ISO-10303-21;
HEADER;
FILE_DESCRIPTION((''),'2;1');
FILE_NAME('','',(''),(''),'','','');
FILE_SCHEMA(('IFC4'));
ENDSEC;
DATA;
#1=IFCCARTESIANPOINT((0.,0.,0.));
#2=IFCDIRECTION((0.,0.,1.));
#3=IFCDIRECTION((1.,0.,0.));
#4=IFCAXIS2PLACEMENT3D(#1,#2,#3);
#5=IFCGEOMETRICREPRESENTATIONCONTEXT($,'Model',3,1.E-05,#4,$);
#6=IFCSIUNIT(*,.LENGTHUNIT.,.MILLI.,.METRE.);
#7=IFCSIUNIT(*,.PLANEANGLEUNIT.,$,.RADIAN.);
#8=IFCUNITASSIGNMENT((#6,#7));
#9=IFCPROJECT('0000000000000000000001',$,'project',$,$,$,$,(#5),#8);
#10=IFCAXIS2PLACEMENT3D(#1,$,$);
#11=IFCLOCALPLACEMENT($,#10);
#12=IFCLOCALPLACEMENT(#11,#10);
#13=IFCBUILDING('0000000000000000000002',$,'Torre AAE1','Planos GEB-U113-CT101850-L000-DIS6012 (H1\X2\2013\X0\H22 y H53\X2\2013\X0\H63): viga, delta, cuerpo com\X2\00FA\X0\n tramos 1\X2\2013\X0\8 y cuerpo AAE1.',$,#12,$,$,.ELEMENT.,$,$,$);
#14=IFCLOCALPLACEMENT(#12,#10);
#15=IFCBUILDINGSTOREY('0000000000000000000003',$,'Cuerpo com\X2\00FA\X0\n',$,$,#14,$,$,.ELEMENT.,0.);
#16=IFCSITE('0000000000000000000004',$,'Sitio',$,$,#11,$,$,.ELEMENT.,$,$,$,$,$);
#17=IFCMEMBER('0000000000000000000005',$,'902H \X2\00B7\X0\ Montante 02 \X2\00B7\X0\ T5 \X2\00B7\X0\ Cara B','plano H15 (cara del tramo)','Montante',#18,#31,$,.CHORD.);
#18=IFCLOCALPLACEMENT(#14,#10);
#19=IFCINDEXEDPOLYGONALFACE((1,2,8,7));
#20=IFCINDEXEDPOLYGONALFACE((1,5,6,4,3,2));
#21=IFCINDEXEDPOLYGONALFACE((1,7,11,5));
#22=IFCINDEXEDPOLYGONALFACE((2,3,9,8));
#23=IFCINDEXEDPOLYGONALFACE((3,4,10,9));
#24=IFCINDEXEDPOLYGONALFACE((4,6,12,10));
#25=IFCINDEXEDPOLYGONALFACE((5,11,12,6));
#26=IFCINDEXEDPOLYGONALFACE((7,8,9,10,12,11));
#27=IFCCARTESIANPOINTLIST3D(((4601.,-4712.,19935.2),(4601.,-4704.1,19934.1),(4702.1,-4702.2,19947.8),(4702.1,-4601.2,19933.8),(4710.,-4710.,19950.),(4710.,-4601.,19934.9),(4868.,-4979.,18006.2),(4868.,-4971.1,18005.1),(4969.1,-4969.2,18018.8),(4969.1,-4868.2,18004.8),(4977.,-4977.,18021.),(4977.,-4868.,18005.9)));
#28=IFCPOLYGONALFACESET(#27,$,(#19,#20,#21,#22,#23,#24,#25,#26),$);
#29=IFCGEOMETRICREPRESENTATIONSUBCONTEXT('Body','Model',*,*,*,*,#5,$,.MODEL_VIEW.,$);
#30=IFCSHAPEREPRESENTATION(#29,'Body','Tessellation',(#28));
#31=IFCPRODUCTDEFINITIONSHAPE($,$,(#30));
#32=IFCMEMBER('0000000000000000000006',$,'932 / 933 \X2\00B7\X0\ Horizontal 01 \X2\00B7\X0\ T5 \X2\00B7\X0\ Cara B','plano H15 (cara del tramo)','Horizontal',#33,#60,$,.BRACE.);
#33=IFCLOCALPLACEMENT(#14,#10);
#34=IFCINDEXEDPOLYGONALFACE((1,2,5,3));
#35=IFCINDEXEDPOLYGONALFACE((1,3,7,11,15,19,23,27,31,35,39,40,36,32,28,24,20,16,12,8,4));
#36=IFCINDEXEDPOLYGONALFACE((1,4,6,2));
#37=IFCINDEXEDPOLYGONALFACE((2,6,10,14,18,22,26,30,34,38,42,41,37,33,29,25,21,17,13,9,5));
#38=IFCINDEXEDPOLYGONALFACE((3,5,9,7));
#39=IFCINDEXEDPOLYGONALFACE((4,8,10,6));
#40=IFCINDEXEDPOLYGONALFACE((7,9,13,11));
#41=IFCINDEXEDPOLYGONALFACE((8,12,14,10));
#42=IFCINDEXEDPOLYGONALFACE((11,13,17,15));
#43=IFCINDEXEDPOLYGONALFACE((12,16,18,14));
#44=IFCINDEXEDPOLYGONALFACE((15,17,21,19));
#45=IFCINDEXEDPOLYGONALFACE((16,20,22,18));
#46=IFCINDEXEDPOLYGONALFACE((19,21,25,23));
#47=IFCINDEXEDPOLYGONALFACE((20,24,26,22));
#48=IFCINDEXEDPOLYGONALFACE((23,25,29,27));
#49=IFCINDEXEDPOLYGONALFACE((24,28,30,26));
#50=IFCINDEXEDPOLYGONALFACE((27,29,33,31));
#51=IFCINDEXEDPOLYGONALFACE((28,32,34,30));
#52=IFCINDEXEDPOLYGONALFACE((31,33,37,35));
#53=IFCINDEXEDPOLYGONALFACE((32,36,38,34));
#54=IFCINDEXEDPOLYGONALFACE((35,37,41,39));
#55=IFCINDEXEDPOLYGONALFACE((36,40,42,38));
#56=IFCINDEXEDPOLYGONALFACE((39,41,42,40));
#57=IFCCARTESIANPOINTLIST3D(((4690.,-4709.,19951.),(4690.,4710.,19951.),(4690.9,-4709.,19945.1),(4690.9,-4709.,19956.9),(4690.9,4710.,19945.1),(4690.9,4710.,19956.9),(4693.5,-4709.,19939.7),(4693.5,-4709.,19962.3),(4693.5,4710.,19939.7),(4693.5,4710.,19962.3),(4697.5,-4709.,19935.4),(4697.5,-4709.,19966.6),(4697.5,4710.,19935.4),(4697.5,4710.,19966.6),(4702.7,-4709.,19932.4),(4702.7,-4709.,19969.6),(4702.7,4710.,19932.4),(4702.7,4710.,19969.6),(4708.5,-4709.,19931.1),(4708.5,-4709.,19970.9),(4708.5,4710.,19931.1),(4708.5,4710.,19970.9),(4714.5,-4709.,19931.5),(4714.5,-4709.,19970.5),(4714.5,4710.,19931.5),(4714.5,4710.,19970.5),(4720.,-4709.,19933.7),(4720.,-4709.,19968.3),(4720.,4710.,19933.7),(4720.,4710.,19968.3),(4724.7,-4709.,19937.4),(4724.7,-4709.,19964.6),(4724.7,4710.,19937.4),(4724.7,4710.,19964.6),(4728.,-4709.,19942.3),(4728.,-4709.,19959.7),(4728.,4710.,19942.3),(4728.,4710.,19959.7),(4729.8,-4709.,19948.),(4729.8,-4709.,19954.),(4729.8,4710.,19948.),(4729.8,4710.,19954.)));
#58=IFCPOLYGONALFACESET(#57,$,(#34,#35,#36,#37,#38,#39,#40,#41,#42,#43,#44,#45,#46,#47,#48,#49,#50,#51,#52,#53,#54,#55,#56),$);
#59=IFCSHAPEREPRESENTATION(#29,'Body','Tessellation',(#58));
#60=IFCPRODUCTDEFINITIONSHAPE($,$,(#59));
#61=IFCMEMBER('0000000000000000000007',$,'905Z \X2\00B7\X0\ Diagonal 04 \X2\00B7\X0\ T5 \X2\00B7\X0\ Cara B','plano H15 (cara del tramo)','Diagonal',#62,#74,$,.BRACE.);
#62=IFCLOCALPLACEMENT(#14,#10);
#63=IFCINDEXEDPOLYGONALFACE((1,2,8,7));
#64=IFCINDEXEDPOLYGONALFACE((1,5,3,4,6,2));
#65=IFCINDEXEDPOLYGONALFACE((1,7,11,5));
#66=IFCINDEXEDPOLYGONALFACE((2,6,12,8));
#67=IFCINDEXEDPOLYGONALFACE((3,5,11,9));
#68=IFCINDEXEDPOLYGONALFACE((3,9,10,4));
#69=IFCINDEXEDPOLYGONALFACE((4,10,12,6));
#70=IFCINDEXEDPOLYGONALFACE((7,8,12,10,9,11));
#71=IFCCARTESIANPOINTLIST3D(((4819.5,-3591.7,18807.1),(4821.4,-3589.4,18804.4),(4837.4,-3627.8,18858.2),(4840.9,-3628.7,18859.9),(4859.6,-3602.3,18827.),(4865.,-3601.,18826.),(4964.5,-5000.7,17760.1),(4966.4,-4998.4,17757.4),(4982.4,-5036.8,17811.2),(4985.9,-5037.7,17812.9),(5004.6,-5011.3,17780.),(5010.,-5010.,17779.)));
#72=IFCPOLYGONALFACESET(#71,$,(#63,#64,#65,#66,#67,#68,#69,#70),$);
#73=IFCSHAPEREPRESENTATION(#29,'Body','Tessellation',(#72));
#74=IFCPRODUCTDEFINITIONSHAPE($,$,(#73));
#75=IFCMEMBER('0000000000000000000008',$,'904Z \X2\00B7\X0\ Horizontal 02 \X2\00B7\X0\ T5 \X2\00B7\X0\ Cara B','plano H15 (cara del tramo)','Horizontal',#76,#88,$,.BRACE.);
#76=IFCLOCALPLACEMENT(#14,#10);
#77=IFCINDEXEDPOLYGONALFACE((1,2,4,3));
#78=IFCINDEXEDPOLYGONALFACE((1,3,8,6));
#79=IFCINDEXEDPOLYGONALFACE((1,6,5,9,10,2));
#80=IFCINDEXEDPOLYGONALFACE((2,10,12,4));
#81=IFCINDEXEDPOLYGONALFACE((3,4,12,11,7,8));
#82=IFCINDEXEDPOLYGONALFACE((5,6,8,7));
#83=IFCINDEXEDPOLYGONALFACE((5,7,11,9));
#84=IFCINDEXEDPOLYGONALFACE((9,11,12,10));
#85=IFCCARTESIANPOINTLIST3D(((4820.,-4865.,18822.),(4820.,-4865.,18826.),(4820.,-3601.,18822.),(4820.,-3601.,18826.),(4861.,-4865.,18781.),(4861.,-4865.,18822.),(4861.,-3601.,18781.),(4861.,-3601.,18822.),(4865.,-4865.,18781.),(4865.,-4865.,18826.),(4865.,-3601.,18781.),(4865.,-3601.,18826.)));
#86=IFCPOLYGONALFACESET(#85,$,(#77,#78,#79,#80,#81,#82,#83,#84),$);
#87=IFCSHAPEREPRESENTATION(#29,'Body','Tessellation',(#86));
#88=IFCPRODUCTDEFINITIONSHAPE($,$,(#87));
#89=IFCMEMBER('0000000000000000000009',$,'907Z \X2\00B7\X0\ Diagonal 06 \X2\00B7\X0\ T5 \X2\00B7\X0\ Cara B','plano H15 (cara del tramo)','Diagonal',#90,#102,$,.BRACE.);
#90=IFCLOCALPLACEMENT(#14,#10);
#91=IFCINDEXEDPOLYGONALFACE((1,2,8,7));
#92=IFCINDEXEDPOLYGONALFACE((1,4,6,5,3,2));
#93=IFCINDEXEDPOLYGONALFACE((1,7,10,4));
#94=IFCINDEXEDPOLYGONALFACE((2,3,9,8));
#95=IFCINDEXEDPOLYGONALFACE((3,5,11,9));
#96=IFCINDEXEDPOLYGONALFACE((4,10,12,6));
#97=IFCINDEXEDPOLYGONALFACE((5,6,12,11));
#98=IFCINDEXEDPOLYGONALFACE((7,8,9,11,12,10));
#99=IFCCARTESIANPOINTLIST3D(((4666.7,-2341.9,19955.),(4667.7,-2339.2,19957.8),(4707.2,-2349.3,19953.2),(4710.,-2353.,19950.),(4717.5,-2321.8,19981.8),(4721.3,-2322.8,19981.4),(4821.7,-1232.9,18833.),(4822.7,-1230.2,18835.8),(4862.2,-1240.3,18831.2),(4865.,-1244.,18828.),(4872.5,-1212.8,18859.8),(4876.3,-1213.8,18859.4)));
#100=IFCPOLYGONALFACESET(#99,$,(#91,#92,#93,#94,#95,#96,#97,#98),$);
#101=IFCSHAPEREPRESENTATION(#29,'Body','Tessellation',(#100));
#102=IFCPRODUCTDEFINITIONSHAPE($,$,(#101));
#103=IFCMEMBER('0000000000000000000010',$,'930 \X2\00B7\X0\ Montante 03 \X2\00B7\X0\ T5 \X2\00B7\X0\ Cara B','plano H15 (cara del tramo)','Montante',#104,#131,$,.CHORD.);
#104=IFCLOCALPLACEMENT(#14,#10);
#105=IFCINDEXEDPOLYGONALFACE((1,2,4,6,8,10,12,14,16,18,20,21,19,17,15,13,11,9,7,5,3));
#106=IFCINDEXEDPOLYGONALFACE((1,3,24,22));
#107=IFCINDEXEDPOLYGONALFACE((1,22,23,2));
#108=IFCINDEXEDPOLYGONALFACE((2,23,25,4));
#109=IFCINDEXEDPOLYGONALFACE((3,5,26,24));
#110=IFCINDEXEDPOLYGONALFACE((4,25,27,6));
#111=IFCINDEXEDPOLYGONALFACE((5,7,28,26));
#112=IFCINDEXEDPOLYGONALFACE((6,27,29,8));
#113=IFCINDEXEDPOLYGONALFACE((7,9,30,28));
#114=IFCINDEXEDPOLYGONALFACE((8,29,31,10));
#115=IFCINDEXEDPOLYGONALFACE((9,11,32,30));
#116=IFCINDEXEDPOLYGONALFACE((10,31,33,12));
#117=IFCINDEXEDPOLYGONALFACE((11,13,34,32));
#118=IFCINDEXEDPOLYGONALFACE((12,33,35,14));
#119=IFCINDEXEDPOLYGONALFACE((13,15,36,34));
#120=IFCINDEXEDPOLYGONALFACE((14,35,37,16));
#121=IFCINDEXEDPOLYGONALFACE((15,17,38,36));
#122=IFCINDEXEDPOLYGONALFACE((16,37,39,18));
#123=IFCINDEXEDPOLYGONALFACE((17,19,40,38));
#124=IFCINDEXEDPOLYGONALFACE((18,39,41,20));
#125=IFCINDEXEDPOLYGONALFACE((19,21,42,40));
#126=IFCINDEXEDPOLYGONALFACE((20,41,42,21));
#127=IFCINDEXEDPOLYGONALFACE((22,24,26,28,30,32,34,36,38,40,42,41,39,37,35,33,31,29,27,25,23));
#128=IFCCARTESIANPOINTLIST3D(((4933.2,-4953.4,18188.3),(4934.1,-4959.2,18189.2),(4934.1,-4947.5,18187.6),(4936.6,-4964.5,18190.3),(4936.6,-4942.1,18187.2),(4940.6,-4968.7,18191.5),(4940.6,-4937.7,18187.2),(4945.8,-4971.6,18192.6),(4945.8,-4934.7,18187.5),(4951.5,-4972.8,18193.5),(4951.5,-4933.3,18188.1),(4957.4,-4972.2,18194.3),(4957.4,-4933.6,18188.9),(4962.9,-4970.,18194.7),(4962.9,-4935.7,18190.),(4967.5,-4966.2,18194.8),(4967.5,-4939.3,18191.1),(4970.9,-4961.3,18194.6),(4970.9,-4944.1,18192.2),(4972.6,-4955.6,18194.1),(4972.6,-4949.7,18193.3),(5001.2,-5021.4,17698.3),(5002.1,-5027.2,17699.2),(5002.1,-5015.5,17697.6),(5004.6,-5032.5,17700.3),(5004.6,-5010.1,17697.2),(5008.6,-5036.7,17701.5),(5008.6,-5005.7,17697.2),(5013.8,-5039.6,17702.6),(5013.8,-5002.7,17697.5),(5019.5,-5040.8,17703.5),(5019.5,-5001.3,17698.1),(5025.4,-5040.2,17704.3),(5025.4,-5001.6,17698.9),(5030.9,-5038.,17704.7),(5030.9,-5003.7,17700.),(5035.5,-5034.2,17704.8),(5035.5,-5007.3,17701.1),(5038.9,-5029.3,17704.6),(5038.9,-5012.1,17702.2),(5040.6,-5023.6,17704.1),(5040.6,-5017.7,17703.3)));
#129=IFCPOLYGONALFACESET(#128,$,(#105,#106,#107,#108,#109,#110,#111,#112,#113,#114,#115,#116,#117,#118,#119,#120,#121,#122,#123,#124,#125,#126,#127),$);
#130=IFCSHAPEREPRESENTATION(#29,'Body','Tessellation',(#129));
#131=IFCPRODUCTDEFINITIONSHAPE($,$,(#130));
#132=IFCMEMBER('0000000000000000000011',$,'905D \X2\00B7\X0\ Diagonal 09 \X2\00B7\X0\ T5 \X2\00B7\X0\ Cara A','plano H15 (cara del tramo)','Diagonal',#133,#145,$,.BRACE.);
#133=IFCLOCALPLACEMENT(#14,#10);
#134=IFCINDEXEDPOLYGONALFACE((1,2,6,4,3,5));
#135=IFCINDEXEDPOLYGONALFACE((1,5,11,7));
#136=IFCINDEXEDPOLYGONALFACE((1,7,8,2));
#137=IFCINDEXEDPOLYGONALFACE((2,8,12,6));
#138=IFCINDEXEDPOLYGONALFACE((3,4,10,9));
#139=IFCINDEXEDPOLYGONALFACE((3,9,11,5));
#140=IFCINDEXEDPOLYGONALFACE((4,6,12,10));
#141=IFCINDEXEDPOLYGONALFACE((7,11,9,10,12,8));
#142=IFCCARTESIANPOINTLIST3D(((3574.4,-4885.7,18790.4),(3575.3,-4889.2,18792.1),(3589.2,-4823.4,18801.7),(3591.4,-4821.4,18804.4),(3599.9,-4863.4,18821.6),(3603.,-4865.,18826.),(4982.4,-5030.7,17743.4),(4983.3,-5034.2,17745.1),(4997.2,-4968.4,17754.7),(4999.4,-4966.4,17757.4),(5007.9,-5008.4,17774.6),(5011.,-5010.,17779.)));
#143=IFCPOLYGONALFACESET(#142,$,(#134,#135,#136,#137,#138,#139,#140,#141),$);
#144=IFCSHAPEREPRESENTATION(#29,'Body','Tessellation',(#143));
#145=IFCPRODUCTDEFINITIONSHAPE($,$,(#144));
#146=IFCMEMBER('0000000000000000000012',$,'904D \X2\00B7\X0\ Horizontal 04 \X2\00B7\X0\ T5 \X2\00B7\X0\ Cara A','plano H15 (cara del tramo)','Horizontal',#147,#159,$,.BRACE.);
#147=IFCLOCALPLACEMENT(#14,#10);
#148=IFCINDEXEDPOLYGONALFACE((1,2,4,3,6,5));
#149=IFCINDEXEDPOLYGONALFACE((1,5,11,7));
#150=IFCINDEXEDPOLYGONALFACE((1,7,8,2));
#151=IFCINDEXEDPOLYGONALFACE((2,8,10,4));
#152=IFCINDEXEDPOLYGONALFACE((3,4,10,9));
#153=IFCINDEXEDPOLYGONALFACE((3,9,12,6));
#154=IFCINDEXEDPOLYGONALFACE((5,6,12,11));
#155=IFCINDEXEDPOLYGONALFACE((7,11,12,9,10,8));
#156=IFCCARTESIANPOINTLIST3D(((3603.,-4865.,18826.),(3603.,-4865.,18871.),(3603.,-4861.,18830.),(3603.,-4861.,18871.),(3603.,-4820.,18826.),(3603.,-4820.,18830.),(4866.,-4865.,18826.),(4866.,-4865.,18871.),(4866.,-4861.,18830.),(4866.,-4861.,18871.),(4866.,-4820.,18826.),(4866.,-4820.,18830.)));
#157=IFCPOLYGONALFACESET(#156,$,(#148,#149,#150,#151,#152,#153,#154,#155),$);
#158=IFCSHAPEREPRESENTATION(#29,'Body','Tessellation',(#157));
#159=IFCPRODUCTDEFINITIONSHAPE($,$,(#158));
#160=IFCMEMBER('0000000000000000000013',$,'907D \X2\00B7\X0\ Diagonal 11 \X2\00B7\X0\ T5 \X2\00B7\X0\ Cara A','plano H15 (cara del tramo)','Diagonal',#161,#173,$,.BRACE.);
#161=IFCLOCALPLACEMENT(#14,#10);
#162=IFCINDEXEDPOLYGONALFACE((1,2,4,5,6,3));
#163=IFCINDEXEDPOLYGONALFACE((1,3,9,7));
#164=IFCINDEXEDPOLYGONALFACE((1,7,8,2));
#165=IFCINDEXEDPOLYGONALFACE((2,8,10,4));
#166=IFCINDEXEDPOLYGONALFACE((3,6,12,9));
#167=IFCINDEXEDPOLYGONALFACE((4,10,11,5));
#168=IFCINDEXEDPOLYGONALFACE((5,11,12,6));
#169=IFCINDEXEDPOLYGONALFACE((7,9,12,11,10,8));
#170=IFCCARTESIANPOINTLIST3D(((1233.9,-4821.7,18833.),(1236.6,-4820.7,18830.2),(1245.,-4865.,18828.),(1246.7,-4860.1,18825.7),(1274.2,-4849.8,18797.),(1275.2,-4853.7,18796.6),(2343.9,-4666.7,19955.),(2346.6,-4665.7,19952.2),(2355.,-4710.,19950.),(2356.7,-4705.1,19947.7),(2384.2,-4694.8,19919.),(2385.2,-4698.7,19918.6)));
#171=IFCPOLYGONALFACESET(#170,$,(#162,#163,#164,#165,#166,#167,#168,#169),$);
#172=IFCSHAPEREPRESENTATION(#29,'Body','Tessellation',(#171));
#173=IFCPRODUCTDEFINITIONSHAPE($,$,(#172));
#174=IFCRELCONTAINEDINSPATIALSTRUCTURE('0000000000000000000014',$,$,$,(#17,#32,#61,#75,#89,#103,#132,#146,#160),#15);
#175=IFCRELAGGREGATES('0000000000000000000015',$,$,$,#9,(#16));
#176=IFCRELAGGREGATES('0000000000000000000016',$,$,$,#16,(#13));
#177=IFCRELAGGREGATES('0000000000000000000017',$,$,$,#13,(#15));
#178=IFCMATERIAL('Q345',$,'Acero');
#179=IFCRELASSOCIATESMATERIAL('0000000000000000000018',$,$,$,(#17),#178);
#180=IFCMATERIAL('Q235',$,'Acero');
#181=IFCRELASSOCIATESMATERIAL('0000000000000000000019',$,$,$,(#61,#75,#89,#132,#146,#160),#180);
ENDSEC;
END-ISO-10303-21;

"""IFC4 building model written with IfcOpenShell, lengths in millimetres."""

from ifc_helpers import new_model, si_unit, frame, frame_2d, origin, origin_with_axes, place, context, subcontext, project, spatial, circle, l_section, extrude, material, element, save


model = new_model("IFC4")

# Units and contexts
model_context = context("Model", 3, precision=1e-05, world=origin_with_axes())
body_context = subcontext(model_context, "Body", "Model", "MODEL_VIEW")
ifc_project = project(units=[si_unit("LENGTHUNIT", "METRE", prefix="MILLI"), si_unit("PLANEANGLEUNIT", "RADIAN")], contexts=[model_context])

# Site, building, storey
site_placement = place(None, origin())
site = spatial("IfcSite", under=ifc_project, at=site_placement, Name="Sitio", CompositionType="ELEMENT")
building_placement = place(site_placement, origin())
building = spatial("IfcBuilding", under=site, at=building_placement, Name="Torre AAE1", Description="Planos GEB-U113-CT101850-L000-DIS6012 (H1–H22 y H53–H63): viga, delta, cuerpo común tramos 1–8 y cuerpo AAE1.", CompositionType="ELEMENT")
storey_placement = place(building_placement, origin())
storey = spatial("IfcBuildingStorey", under=building, at=storey_placement, Name="Cuerpo común", CompositionType="ELEMENT", Elevation=0.0)

# Members
ifc_material_1 = material(Name="Q235", Category="Acero")
ifc_material_2 = material(Name="Q345", Category="Acero")
member_1_placement = place(storey_placement, frame((4710.0, -4710.0, 19950.0), z_axis=(0.135836, -0.135836, -0.981375), x_axis=(-0.990731, -0.018624, -0.134553)))
element("IfcMember", 1, at=member_1_placement, inside=storey, material=ifc_material_2, Name="902H · Montante 02 · T5 · Cara B", Description="plano H15 (cara del tramo)", ObjectType="Montante", PredefinedType="CHORD", context=body_context, shape_type="SweptSolid", body=[
    extrude(l_section(Depth=110.0, Width=110.0, Thickness=8.0, at=frame_2d((55.0, 55.0))), None, (0.0, 0.0, 1.0), 1965.6),
])
member_2_placement = place(storey_placement, frame((4710.0, -4709.0, 19951.0), z_axis=(0.0, 1.0, 0.0), x_axis=(-1.0, 0.0, 0.0)))
element("IfcMember", 2, at=member_2_placement, inside=storey, Name="932 / 933 · Horizontal 01 · T5 · Cara B", Description="plano H15 (cara del tramo)", ObjectType="Horizontal", PredefinedType="BRACE", context=body_context, shape_type="SweptSolid", body=[
    extrude(circle(Radius=20.0), None, (0.0, 0.0, 1.0), 9419.0),
])
member_3_placement = place(storey_placement, frame((5010.0, -5010.0, 17779.0), z_axis=(-0.082321, 0.799934, 0.594415), x_axis=(-0.871806, 0.231191, -0.431862)))
element("IfcMember", 3, at=member_3_placement, inside=storey, material=ifc_material_1, Name="905Z · Diagonal 04 · T5 · Cara B", Description="plano H15 (cara del tramo)", ObjectType="Diagonal", PredefinedType="BRACE", context=body_context, shape_type="SweptSolid", body=[
    extrude(l_section(Depth=50.0, Width=50.0, Thickness=4.0, at=frame_2d((25.0, 25.0))), None, (0.0, 0.0, 1.0), 1761.4),
])
member_4_placement = place(storey_placement, frame((4865.0, -3601.0, 18826.0), z_axis=(0.0, -1.0, 0.0), x_axis=(-1.0, 0.0, 0.0)))
element("IfcMember", 4, at=member_4_placement, inside=storey, material=ifc_material_1, Name="904Z · Horizontal 02 · T5 · Cara B", Description="plano H15 (cara del tramo)", ObjectType="Horizontal", PredefinedType="BRACE", context=body_context, shape_type="SweptSolid", body=[
    extrude(l_section(Depth=45.0, Width=45.0, Thickness=4.0, at=frame_2d((22.5, 22.5))), None, (0.0, 0.0, 1.0), 1264.0),
])
member_5_placement = place(storey_placement, frame((4710.0, -2353.0, 19950.0), z_axis=(0.097781, 0.699606, -0.707807), x_axis=(-0.962791, 0.246544, 0.110682)))
element("IfcMember", 5, at=member_5_placement, inside=storey, material=ifc_material_1, Name="907Z · Diagonal 06 · T5 · Cara B", Description="plano H15 (cara del tramo)", ObjectType="Diagonal", PredefinedType="BRACE", context=body_context, shape_type="SweptSolid", body=[
    extrude(l_section(Depth=45.0, Width=45.0, Thickness=4.0, at=frame_2d((22.5, 22.5))), None, (0.0, 0.0, 1.0), 1585.2),
])
member_6_placement = place(storey_placement, frame((4953.0, -4953.0, 18191.0), z_axis=(0.136178, -0.136178, -0.98128), x_axis=(-0.990684, -0.018719, -0.134885)))
element("IfcMember", 6, at=member_6_placement, inside=storey, Name="930 · Montante 03 · T5 · Cara B", Description="plano H15 (cara del tramo)", ObjectType="Montante", PredefinedType="CHORD", context=body_context, shape_type="SweptSolid", body=[
    extrude(circle(Radius=20.0), None, (0.0, 0.0, 1.0), 499.3),
])
member_7_placement = place(storey_placement, frame((5011.0, -5010.0, 17779.0), z_axis=(-0.799729, 0.082358, 0.594685), x_axis=(-0.231509, 0.871631, -0.432045)))
element("IfcMember", 7, at=member_7_placement, inside=storey, material=ifc_material_1, Name="905D · Diagonal 09 · T5 · Cara A", Description="plano H15 (cara del tramo)", ObjectType="Diagonal", PredefinedType="BRACE", context=body_context, shape_type="SweptSolid", body=[
    extrude(l_section(Depth=50.0, Width=50.0, Thickness=4.0, at=frame_2d((25.0, 25.0))), None, (0.0, 0.0, 1.0), 1760.6),
])
member_8_placement = place(storey_placement, frame((3603.0, -4865.0, 18826.0), z_axis=(1.0, 0.0, 0.0), x_axis=(0.0, 1.0, 0.0)))
element("IfcMember", 8, at=member_8_placement, inside=storey, material=ifc_material_1, Name="904D · Horizontal 04 · T5 · Cara A", Description="plano H15 (cara del tramo)", ObjectType="Horizontal", PredefinedType="BRACE", context=body_context, shape_type="SweptSolid", body=[
    extrude(l_section(Depth=45.0, Width=45.0, Thickness=4.0, at=frame_2d((22.5, 22.5))), None, (0.0, 0.0, 1.0), 1263.0),
])
member_9_placement = place(storey_placement, frame((2355.0, -4710.0, 19950.0), z_axis=(-0.699928, -0.097738, -0.707495), x_axis=(-0.246524, 0.962772, 0.110884)))
element("IfcMember", 9, at=member_9_placement, inside=storey, material=ifc_material_1, Name="907D · Diagonal 11 · T5 · Cara A", Description="plano H15 (cara del tramo)", ObjectType="Diagonal", PredefinedType="BRACE", context=body_context, shape_type="SweptSolid", body=[
    extrude(l_section(Depth=45.0, Width=45.0, Thickness=4.0, at=frame_2d((22.5, 22.5))), None, (0.0, 0.0, 1.0), 1585.9),
])

save(model, "model.ifc")
